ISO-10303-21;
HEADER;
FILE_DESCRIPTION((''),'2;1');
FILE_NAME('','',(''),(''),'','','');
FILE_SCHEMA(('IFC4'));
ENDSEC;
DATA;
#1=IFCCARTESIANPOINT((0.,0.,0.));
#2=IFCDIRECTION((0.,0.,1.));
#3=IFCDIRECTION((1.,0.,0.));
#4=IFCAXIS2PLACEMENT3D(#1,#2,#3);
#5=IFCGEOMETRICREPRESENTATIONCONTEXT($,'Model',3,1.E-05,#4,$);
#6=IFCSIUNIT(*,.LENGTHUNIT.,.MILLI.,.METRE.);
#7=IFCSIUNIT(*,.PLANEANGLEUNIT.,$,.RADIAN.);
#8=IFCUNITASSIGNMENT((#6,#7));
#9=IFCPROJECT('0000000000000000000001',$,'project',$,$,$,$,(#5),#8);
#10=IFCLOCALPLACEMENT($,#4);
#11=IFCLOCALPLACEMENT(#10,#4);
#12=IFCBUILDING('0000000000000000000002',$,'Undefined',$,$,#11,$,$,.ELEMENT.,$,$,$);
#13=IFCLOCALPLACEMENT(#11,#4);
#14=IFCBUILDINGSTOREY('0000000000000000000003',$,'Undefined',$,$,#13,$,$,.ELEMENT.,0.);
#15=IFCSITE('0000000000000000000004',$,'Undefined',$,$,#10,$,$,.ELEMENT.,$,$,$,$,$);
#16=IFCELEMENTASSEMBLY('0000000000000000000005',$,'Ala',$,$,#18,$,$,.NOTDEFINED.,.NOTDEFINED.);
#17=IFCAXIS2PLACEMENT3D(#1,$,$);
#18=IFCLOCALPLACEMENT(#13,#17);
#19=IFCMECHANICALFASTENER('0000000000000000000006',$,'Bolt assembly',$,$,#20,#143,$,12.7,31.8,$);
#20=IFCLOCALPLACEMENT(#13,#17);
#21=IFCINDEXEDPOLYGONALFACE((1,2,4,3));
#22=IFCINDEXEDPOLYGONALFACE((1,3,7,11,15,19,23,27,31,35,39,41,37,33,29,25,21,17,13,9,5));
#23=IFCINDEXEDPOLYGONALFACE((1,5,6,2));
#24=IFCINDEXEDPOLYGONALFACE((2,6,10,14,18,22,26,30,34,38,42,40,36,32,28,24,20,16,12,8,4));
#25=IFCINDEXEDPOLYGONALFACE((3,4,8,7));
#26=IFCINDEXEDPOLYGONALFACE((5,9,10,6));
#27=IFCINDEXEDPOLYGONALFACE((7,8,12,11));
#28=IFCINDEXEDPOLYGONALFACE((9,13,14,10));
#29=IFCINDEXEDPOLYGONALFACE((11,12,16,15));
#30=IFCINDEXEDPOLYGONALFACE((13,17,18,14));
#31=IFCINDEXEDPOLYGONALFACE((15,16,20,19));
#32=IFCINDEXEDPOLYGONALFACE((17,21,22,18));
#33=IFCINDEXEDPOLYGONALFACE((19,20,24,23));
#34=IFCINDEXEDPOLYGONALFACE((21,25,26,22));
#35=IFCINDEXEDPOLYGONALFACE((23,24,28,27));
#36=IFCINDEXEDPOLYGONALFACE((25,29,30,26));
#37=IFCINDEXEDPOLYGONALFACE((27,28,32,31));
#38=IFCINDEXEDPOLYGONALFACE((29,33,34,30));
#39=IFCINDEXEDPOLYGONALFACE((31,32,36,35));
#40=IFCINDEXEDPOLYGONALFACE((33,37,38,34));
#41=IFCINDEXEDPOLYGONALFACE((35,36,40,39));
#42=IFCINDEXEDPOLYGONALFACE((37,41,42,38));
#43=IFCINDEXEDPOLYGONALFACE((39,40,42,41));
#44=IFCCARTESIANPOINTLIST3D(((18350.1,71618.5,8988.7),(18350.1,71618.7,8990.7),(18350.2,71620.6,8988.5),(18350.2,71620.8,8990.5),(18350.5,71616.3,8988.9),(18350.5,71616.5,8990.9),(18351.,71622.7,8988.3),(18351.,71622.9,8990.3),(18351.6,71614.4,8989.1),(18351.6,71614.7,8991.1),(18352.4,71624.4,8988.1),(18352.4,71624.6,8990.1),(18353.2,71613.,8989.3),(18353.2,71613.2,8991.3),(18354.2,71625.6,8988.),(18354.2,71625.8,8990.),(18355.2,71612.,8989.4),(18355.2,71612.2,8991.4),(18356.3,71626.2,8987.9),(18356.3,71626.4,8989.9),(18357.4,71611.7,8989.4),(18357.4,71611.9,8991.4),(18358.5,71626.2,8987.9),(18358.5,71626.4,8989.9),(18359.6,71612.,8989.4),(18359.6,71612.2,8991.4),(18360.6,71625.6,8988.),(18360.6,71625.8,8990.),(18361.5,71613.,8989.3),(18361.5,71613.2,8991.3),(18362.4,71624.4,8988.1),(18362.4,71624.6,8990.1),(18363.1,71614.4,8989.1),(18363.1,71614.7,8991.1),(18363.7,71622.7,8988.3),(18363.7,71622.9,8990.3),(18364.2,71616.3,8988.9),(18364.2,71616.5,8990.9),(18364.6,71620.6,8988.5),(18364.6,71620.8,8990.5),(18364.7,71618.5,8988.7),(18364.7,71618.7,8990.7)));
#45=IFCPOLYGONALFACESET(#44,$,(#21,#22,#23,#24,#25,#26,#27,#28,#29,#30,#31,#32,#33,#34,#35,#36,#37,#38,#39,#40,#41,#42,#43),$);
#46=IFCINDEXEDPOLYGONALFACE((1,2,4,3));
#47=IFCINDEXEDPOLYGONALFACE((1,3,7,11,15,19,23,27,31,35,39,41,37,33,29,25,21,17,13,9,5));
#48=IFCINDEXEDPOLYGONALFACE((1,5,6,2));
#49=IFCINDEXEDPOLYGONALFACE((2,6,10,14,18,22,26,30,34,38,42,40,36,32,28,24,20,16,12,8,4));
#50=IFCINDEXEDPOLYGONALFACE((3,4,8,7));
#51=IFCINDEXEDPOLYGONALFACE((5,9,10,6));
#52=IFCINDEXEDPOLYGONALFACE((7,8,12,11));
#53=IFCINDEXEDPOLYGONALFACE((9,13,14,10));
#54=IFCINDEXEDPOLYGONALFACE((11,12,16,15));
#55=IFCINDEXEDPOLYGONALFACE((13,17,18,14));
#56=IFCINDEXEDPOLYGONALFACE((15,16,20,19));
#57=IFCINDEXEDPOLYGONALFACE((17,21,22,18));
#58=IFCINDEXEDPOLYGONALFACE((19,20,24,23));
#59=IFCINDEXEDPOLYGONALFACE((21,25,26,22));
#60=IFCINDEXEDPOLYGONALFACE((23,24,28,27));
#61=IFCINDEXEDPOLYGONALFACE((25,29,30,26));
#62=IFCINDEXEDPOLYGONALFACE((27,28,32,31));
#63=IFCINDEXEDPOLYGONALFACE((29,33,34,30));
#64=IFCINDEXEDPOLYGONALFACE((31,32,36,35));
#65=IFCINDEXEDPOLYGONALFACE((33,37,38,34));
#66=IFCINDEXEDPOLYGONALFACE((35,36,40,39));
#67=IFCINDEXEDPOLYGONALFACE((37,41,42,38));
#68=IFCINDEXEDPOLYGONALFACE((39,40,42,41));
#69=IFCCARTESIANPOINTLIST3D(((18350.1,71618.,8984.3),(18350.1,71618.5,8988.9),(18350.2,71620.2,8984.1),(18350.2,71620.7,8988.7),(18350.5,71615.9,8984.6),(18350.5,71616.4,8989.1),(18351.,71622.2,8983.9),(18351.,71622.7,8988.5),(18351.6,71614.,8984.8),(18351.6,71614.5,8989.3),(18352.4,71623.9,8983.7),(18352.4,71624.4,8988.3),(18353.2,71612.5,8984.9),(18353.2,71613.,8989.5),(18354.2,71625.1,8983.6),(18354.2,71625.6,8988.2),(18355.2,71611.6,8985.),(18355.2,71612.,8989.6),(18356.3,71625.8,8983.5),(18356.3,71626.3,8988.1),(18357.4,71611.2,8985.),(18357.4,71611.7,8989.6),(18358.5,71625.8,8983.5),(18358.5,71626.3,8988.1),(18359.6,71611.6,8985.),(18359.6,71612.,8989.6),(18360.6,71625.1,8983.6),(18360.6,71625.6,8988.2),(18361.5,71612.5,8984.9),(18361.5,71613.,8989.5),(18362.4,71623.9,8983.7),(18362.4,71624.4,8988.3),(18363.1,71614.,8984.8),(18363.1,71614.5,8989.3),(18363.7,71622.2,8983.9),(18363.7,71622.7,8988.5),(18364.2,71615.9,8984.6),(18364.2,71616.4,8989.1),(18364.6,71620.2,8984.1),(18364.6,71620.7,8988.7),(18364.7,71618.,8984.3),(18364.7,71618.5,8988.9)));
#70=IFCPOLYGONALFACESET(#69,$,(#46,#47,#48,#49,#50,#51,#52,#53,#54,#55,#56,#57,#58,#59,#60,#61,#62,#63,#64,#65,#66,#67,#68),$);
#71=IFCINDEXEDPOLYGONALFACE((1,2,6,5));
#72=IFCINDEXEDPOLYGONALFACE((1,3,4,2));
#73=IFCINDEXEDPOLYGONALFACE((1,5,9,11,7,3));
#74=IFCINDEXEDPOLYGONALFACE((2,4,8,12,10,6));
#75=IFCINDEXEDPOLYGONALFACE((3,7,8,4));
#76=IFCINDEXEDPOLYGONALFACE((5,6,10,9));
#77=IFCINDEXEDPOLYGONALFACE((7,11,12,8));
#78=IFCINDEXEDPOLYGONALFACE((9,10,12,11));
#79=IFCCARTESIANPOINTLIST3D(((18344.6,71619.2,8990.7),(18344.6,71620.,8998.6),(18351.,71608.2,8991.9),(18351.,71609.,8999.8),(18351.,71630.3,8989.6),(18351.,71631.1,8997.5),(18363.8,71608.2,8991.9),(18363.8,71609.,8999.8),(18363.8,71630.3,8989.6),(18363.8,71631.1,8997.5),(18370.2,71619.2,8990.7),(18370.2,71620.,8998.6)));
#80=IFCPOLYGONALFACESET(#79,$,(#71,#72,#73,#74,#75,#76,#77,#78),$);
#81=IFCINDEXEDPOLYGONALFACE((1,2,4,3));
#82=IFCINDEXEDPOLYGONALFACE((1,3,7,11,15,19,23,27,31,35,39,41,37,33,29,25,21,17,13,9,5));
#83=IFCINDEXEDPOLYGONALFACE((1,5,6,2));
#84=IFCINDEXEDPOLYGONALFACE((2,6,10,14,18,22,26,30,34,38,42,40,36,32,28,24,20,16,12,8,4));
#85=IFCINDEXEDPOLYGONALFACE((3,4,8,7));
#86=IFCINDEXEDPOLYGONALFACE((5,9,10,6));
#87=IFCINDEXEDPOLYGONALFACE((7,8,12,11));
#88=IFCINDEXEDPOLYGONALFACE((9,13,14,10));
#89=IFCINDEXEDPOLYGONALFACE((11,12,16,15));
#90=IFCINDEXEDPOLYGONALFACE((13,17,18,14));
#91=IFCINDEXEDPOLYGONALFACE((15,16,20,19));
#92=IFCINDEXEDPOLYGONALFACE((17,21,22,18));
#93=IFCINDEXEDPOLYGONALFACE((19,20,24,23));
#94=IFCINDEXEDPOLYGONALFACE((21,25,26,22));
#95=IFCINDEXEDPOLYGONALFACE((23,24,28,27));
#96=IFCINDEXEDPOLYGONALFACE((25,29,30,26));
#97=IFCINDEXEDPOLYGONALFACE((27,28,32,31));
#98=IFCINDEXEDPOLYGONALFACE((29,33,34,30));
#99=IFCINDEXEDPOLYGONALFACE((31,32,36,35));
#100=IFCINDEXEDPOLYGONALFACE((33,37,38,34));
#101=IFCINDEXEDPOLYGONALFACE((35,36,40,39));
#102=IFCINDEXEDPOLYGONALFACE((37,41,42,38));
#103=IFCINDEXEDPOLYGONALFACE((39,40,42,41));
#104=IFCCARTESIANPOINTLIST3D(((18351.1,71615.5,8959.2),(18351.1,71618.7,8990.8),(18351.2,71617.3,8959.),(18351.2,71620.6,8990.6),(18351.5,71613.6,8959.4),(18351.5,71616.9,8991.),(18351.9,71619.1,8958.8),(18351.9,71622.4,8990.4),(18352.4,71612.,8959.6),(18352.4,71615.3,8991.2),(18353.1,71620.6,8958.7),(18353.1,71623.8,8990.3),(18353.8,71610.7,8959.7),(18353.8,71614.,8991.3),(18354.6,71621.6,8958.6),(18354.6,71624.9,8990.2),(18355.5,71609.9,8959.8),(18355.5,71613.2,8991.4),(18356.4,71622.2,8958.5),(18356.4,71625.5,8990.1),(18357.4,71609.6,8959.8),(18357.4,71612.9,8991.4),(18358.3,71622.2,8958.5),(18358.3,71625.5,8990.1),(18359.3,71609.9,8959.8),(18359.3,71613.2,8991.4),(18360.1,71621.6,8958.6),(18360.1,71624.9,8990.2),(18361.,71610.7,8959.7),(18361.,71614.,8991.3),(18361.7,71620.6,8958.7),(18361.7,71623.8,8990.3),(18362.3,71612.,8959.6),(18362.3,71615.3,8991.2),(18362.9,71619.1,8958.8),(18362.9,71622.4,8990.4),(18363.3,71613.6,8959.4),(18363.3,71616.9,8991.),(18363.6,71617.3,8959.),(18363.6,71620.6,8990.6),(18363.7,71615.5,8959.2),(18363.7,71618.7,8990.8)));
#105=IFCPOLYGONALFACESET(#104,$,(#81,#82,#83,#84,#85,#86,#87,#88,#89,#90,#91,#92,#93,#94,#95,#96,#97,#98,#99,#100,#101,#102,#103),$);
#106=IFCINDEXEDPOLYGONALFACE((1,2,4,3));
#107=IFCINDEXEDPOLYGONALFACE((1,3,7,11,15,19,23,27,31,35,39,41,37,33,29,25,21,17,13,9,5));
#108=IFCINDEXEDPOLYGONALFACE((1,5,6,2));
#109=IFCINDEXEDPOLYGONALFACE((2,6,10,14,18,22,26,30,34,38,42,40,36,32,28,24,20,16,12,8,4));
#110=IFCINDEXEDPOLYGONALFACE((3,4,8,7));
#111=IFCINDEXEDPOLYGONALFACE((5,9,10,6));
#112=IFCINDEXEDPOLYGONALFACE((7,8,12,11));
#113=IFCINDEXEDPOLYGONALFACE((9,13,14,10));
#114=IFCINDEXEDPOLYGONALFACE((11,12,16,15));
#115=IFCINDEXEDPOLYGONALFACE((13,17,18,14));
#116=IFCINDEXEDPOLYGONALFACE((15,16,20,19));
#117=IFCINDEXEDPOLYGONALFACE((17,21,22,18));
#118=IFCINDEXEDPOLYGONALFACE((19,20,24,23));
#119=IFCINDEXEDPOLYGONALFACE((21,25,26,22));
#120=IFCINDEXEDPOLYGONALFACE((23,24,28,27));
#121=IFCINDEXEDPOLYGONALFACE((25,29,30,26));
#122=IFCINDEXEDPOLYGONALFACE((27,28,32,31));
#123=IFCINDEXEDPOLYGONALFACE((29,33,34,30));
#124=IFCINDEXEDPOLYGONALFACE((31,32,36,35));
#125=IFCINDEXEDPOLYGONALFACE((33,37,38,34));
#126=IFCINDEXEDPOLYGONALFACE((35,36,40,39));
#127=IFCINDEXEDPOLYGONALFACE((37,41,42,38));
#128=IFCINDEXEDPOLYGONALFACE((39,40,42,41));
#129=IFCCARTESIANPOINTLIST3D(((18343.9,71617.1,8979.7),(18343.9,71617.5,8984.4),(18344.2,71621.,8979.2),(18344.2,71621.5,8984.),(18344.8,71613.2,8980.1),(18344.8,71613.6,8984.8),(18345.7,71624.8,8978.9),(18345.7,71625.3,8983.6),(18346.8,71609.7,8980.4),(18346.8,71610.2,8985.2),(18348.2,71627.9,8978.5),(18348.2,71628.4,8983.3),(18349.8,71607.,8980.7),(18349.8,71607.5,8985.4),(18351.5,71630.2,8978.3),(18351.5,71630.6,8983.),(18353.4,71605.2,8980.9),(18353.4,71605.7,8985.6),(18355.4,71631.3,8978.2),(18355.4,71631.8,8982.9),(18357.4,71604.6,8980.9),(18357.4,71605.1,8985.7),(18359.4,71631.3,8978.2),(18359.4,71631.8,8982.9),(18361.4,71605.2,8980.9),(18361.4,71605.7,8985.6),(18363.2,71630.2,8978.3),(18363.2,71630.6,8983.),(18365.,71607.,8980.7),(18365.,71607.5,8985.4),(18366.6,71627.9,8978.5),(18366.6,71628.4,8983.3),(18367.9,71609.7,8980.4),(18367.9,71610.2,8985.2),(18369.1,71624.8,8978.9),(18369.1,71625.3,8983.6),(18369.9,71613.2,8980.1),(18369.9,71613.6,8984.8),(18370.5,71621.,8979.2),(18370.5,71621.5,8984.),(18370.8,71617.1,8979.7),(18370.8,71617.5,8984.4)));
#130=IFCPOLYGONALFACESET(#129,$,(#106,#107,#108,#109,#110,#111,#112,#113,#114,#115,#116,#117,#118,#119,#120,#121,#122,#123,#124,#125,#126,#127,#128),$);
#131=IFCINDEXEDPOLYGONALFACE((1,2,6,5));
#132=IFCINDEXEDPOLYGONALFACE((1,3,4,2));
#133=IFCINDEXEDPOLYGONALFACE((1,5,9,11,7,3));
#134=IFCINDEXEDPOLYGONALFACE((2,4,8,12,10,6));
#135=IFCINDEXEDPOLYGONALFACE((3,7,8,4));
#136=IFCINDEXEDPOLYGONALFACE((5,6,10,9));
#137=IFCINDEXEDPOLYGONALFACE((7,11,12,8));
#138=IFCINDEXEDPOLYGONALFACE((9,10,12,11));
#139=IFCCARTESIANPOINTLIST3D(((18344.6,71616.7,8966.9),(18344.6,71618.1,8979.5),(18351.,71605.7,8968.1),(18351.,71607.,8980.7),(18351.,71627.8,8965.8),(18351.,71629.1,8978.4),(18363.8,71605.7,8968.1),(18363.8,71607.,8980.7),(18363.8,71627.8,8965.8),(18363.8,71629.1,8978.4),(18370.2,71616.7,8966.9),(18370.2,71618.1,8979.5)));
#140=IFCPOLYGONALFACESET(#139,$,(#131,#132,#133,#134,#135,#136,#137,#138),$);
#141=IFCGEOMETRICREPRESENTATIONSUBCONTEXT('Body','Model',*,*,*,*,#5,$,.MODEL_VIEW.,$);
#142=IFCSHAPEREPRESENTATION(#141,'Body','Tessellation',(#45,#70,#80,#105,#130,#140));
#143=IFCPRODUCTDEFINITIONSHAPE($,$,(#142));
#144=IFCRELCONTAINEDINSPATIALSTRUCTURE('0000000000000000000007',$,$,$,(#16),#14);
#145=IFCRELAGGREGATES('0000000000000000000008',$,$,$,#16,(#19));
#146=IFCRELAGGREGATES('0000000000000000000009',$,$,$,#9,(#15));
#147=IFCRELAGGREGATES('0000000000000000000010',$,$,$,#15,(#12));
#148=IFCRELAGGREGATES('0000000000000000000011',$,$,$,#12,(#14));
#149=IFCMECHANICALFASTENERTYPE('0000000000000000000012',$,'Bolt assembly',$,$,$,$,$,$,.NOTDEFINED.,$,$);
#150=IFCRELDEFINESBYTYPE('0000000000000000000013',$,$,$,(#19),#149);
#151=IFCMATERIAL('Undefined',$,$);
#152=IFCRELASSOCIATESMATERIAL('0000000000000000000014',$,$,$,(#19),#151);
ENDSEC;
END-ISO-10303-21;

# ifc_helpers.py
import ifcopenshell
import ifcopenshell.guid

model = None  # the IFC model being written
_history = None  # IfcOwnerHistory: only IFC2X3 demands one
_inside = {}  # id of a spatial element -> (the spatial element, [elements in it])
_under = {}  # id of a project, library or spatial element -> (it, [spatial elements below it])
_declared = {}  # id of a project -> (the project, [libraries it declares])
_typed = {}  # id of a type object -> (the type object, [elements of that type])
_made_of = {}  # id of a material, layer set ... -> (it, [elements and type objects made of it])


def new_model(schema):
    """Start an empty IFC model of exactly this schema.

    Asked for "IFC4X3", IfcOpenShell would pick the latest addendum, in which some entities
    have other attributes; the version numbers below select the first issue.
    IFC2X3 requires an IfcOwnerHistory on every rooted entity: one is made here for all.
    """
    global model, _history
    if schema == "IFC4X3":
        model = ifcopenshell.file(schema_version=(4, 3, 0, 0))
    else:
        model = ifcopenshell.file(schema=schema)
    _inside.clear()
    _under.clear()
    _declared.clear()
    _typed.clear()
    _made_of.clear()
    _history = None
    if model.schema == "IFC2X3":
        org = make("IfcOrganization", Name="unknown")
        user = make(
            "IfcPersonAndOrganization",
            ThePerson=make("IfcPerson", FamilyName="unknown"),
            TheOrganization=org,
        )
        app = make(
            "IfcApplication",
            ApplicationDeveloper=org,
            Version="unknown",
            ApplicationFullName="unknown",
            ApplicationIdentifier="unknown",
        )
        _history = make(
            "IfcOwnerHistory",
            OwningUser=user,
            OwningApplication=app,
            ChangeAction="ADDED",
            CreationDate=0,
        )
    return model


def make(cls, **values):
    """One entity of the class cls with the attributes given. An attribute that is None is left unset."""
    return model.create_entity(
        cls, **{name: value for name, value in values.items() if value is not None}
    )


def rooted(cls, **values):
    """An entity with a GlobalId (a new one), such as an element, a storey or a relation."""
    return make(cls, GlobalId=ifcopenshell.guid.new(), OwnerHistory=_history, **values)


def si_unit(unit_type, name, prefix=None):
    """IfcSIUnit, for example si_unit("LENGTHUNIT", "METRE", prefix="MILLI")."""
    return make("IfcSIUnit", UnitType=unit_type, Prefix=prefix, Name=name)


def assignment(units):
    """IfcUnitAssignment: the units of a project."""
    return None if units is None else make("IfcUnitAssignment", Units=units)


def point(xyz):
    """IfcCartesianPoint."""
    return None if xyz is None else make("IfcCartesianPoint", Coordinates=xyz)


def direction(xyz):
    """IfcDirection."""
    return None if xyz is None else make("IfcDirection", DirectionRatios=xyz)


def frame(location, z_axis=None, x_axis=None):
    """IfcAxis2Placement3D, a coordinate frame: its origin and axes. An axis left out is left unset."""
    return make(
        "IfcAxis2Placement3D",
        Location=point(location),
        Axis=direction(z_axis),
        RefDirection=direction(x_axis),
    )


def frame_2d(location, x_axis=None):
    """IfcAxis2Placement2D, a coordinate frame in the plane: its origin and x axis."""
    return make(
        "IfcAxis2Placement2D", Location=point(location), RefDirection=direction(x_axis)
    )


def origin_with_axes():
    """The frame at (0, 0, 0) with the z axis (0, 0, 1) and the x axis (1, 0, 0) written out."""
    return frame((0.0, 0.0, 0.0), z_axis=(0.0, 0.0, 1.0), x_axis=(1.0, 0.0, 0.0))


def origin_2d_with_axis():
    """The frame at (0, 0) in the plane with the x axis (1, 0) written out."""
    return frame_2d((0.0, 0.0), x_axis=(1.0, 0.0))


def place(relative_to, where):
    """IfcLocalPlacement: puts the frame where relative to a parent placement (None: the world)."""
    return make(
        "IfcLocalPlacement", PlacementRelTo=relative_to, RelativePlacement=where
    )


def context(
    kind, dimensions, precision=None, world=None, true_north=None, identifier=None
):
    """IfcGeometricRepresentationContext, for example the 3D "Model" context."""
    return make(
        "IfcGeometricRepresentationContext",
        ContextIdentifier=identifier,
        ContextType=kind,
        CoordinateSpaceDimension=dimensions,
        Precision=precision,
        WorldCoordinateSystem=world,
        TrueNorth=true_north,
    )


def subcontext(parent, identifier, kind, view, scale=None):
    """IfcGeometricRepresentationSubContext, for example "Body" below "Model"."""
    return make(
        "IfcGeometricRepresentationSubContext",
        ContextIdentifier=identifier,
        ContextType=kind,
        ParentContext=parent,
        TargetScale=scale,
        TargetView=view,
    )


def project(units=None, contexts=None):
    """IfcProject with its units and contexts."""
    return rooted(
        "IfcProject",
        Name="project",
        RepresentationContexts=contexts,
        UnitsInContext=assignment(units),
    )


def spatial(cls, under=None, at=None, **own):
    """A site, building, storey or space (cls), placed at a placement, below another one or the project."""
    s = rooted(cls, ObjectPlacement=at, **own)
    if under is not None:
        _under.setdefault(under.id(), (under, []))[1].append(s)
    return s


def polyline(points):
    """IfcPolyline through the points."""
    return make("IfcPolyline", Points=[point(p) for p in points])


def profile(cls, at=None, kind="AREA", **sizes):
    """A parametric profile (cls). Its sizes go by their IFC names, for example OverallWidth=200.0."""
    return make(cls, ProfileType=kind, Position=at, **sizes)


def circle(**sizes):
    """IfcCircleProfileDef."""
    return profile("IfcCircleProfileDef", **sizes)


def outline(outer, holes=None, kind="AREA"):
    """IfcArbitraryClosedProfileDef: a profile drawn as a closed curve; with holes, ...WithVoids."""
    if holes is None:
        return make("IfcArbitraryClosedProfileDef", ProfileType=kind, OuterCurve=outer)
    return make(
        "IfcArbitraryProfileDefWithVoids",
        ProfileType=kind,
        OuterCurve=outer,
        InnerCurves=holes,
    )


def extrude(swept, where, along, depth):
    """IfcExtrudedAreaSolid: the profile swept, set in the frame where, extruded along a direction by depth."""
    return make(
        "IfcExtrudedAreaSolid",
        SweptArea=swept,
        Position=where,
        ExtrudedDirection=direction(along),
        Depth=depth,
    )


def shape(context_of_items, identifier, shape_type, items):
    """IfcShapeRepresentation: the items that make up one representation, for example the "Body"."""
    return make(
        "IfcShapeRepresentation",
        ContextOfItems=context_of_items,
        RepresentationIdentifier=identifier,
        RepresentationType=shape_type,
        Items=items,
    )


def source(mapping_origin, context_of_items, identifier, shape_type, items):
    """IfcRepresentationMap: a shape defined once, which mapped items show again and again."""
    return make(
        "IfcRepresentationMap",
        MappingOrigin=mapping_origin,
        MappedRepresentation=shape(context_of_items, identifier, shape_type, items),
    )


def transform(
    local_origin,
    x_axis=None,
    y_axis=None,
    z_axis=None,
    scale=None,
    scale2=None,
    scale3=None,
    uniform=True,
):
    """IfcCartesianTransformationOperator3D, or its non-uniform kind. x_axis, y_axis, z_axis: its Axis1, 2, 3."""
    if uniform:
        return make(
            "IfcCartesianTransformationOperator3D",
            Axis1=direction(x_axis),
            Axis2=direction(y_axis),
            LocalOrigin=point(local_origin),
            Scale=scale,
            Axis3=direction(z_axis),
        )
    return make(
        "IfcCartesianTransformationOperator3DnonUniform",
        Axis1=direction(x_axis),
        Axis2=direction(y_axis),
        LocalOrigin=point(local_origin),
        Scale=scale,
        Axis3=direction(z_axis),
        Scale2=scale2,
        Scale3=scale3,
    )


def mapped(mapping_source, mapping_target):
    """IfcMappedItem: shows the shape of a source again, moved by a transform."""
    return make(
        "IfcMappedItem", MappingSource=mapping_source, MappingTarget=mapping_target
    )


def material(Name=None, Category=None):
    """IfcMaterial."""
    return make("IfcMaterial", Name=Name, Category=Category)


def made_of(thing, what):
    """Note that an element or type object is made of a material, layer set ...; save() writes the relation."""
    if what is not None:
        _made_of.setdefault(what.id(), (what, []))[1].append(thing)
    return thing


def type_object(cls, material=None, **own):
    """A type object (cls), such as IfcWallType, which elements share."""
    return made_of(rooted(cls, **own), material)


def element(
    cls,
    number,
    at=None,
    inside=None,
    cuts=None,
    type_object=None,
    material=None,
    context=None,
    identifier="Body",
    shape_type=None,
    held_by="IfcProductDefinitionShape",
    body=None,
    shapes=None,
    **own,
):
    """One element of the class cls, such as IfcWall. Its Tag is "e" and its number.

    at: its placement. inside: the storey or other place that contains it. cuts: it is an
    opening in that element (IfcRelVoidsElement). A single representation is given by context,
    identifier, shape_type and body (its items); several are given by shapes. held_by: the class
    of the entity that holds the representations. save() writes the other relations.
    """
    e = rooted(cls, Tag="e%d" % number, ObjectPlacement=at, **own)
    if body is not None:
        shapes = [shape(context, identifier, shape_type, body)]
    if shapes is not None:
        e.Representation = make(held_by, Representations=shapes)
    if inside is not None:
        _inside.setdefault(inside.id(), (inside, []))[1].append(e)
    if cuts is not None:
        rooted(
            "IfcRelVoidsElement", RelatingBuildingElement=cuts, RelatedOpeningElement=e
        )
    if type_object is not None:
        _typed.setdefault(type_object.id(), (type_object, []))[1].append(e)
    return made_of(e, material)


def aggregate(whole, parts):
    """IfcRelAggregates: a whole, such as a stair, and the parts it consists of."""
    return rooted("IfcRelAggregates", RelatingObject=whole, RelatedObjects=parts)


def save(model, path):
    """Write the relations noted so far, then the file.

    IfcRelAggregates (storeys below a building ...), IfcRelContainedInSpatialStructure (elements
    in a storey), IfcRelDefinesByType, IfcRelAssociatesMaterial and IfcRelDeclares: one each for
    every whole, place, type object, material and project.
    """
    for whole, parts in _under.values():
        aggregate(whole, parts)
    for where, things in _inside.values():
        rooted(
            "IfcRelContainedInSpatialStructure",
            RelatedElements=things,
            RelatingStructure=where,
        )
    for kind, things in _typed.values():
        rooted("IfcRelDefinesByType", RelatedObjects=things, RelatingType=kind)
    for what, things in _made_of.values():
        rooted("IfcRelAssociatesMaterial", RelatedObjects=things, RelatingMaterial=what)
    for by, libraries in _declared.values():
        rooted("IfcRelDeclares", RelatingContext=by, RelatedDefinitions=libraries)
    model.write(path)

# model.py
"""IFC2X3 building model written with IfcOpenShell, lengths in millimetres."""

from ifc_helpers import new_model, si_unit, frame, origin_with_axes, origin_2d_with_axis, place, context, subcontext, project, spatial, polyline, circle, outline, extrude, source, transform, mapped, material, type_object, element, aggregate, save


model = new_model("IFC2X3")

# Units and contexts
model_context = context("Model", 3, precision=1e-05, world=origin_with_axes())
body_context = subcontext(model_context, "Body", "Model", "MODEL_VIEW")
ifc_project = project(units=[si_unit("LENGTHUNIT", "METRE", prefix="MILLI"), si_unit("PLANEANGLEUNIT", "RADIAN")], contexts=[model_context])

# Site, building, storey
site_placement = place(None, origin_with_axes())
site = spatial("IfcSite", under=ifc_project, at=site_placement, Name="Undefined", CompositionType="ELEMENT")
building_placement = place(site_placement, origin_with_axes())
building = spatial("IfcBuilding", under=site, at=building_placement, Name="Undefined", CompositionType="ELEMENT")
storey_placement = place(building_placement, origin_with_axes())
storey = spatial("IfcBuildingStorey", under=building, at=storey_placement, Name="Undefined", CompositionType="ELEMENT", Elevation=0.0)

# Element assembly
assembly_1_placement = place(storey_placement, origin_with_axes())
assembly_1 = element("IfcElementAssembly", 1, at=assembly_1_placement, inside=storey, Name="Ala", AssemblyPlace="NOTDEFINED", PredefinedType="NOTDEFINED")

# Shared definitions
ifc_material_1 = material(Name="Undefined")
mechanical_fastener_type = type_object("IfcMechanicalFastenerType", Name="Bolt assembly")

# Mechanical fastener
shared_shape_1 = source(origin_with_axes(), body_context, "Body", "SweptSolid", [
    extrude(circle(Radius=7.3, at=origin_2d_with_axis()), frame((0.0, -1.9, 0.0), z_axis=(0.0, 1.0, 0.0), x_axis=(1.0, 0.0, 0.0)), (0.0, 0.0, 1.0), 2.0),
    extrude(circle(Radius=7.3, at=origin_2d_with_axis()), frame((0.0, -0.1, 0.0), z_axis=(0.0, 1.0, 0.0), x_axis=(1.0, 0.0, 0.0)), (0.0, 0.0, 1.0), 4.6),
    extrude(outline(polyline([(11.1, -6.4), (11.1, 6.4), (0.0, 12.8), (-11.1, 6.4), (-11.1, -6.4), (0.0, -12.8), (11.1, -6.4)])), frame((0.0, -9.9, 0.0), z_axis=(0.0, 1.0, 0.0), x_axis=(1.0, 0.0, 0.0)), (0.0, 0.0, 1.0), 7.9),
    extrude(circle(Radius=6.3, at=origin_2d_with_axis()), frame((0.0, -2.0, 0.0), z_axis=(0.0, 1.0, 0.0), x_axis=(1.0, 0.0, 0.0)), (0.0, 0.0, 1.0), 31.8),
    extrude(circle(Radius=13.5, at=origin_2d_with_axis()), frame((0.0, 4.5, 0.0), z_axis=(0.0, 1.0, 0.0), x_axis=(1.0, 0.0, 0.0)), (0.0, 0.0, 1.0), 4.8),
    extrude(outline(polyline([(11.1, -6.4), (11.1, 6.4), (0.0, 12.8), (-11.1, 6.4), (-11.1, -6.4), (0.0, -12.8), (11.1, -6.4)])), frame((0.0, 9.3, 0.0), z_axis=(0.0, 1.0, 0.0), x_axis=(1.0, 0.0, 0.0)), (0.0, 0.0, 1.0), 12.7),
])
mechanical_fastener_1_placement = place(assembly_1_placement, frame((18357.4, 71619.0, 8988.8), z_axis=(1.0, 0.0, 0.0), x_axis=(0.0, -0.994665, 0.103162)))
mechanical_fastener_1 = element("IfcMechanicalFastener", 2, at=mechanical_fastener_1_placement, type_object=mechanical_fastener_type, material=ifc_material_1, Name="Bolt assembly", NominalDiameter=12.7, NominalLength=31.8, context=body_context, shape_type="MappedRepresentation", body=[
    mapped(shared_shape_1, transform((0.0, 0.0, 0.0))),
])

aggregate(assembly_1, [mechanical_fastener_1])

save(model, "model.ifc")
